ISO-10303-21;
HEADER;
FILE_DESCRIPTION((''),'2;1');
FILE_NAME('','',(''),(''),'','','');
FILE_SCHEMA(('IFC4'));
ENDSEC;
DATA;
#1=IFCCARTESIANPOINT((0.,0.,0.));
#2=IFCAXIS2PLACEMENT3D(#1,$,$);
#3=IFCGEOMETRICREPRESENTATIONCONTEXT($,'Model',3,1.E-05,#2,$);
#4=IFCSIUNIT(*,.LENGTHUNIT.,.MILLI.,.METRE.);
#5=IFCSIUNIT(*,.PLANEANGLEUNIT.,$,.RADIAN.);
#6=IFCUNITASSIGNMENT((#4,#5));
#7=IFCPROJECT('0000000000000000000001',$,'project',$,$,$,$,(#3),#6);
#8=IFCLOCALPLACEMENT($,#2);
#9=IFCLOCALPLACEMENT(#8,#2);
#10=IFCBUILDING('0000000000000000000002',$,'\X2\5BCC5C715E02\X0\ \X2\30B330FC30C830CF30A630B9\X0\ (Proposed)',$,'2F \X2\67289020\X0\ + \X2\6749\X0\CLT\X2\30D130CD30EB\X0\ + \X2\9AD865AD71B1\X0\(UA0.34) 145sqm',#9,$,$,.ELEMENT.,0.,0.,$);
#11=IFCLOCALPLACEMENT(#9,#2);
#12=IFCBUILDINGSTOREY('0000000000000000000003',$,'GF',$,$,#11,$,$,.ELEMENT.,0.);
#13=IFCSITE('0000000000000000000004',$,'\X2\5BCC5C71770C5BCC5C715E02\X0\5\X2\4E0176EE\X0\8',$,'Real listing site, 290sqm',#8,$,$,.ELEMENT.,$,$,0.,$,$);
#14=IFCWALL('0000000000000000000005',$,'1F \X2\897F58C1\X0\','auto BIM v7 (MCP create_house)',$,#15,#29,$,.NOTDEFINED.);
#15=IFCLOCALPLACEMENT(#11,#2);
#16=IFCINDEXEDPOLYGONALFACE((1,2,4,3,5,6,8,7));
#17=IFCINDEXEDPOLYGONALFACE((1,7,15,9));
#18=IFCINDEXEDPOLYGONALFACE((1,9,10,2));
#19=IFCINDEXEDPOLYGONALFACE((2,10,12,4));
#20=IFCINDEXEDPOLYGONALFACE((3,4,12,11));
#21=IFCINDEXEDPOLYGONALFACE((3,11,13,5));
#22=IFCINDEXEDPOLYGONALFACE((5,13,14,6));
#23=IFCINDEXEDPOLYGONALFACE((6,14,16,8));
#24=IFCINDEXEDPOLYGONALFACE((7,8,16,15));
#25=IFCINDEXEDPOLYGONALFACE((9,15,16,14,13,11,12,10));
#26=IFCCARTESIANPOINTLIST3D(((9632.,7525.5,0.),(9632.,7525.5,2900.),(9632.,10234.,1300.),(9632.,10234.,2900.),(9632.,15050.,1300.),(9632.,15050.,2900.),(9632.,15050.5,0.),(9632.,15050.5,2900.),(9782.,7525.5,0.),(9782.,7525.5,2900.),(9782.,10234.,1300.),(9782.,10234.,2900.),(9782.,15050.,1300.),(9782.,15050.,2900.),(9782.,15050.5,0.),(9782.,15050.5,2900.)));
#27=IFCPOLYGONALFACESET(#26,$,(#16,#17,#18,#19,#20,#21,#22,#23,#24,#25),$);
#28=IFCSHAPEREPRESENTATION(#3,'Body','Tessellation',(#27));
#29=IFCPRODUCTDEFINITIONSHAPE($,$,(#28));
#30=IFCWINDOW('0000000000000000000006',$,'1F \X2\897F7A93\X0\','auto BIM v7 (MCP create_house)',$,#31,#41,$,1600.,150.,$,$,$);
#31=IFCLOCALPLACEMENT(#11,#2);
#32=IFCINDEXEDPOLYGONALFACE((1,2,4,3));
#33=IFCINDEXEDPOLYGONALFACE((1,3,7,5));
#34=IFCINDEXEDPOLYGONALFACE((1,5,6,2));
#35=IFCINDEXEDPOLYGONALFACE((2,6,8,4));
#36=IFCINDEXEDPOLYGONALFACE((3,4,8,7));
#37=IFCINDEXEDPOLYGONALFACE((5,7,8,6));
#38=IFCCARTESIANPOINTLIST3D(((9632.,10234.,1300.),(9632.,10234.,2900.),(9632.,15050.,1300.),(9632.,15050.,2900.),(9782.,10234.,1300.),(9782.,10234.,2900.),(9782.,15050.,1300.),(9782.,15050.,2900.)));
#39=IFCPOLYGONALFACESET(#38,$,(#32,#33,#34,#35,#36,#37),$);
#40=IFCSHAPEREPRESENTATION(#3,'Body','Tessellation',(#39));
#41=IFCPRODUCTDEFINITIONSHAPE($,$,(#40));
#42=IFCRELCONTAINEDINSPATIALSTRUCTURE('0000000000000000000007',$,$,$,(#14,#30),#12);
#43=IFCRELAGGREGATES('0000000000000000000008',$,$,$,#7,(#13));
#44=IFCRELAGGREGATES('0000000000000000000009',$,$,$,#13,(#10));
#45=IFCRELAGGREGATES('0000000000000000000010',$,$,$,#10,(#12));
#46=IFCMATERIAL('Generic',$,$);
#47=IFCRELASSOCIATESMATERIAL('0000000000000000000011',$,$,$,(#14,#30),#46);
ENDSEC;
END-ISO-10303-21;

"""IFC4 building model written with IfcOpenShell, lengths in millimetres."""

from ifc_helpers import new_model, si_unit, frame, frame_2d, origin, place, context, project, spatial, rectangle, extrude, material, element, fill, save


model = new_model("IFC4")

# Units and contexts
model_context = context("Model", 3, precision=1e-05, world=origin())
ifc_project = project(units=[si_unit("LENGTHUNIT", "METRE", prefix="MILLI"), si_unit("PLANEANGLEUNIT", "RADIAN")], contexts=[model_context])

# Site, building, storey
site_placement = place(None, origin())
site = spatial("IfcSite", under=ifc_project, at=site_placement, Name="富山県富山市5丁目8", ObjectType="Real listing site, 290sqm", CompositionType="ELEMENT", RefElevation=0.0)
building_placement = place(site_placement, origin())
building = spatial("IfcBuilding", under=site, at=building_placement, Name="富山市 コートハウス (Proposed)", ObjectType="2F 木造 + 杉CLTパネル + 高断熱(UA0.34) 145sqm", CompositionType="ELEMENT", ElevationOfRefHeight=0.0, ElevationOfTerrain=0.0)
storey_placement = place(building_placement, origin())
storey = spatial("IfcBuildingStorey", under=building, at=storey_placement, Name="GF", CompositionType="ELEMENT", Elevation=0.0)

# Shared definitions
ifc_material = material(Name="Generic")

# Wall, opening, window
wall_1_placement = place(storey_placement, frame((4816.0, 3763.0, 0.0)))
wall_1 = element("IfcWall", 1, at=wall_1_placement, inside=storey, material=ifc_material, Name="1F 西壁", Description="auto BIM v7 (MCP create_house)", PredefinedType="NOTDEFINED", context=model_context, shape_type="SweptSolid", body=[
    extrude(rectangle(XDim=150.0, YDim=7525.0, at=frame_2d((75.0, 3762.0))), frame((4816.0, 3763.0, 0.0)), (0.0, 0.0, 1.0), 2900.0),
])
opening_1_placement = place(storey_placement, frame((4816.0, 5117.0, 650.0)))
opening_1 = element("IfcOpeningElement", 2, at=opening_1_placement, cuts=wall_1, PredefinedType="NOTDEFINED", context=model_context, shape_type="SweptSolid", body=[
    extrude(rectangle(XDim=150.0, YDim=4816.0, at=frame_2d((75.0, 2408.0))), frame((4816.0, 5117.0, 650.0)), (0.0, 0.0, 1.0), 1600.0),
])
window_1_placement = place(storey_placement, frame((4816.0, 5117.0, 650.0)))
window_1 = element("IfcWindow", 3, at=window_1_placement, inside=storey, material=ifc_material, Name="1F 西窓", Description="auto BIM v7 (MCP create_house)", OverallHeight=1600.0, OverallWidth=150.0, context=model_context, shape_type="SweptSolid", body=[
    extrude(rectangle(XDim=150.0, YDim=4816.0, at=frame_2d((75.0, 2408.0))), frame((4816.0, 5117.0, 650.0)), (0.0, 0.0, 1.0), 1600.0),
])
fill(opening_1, window_1)

save(model, "model.ifc")
